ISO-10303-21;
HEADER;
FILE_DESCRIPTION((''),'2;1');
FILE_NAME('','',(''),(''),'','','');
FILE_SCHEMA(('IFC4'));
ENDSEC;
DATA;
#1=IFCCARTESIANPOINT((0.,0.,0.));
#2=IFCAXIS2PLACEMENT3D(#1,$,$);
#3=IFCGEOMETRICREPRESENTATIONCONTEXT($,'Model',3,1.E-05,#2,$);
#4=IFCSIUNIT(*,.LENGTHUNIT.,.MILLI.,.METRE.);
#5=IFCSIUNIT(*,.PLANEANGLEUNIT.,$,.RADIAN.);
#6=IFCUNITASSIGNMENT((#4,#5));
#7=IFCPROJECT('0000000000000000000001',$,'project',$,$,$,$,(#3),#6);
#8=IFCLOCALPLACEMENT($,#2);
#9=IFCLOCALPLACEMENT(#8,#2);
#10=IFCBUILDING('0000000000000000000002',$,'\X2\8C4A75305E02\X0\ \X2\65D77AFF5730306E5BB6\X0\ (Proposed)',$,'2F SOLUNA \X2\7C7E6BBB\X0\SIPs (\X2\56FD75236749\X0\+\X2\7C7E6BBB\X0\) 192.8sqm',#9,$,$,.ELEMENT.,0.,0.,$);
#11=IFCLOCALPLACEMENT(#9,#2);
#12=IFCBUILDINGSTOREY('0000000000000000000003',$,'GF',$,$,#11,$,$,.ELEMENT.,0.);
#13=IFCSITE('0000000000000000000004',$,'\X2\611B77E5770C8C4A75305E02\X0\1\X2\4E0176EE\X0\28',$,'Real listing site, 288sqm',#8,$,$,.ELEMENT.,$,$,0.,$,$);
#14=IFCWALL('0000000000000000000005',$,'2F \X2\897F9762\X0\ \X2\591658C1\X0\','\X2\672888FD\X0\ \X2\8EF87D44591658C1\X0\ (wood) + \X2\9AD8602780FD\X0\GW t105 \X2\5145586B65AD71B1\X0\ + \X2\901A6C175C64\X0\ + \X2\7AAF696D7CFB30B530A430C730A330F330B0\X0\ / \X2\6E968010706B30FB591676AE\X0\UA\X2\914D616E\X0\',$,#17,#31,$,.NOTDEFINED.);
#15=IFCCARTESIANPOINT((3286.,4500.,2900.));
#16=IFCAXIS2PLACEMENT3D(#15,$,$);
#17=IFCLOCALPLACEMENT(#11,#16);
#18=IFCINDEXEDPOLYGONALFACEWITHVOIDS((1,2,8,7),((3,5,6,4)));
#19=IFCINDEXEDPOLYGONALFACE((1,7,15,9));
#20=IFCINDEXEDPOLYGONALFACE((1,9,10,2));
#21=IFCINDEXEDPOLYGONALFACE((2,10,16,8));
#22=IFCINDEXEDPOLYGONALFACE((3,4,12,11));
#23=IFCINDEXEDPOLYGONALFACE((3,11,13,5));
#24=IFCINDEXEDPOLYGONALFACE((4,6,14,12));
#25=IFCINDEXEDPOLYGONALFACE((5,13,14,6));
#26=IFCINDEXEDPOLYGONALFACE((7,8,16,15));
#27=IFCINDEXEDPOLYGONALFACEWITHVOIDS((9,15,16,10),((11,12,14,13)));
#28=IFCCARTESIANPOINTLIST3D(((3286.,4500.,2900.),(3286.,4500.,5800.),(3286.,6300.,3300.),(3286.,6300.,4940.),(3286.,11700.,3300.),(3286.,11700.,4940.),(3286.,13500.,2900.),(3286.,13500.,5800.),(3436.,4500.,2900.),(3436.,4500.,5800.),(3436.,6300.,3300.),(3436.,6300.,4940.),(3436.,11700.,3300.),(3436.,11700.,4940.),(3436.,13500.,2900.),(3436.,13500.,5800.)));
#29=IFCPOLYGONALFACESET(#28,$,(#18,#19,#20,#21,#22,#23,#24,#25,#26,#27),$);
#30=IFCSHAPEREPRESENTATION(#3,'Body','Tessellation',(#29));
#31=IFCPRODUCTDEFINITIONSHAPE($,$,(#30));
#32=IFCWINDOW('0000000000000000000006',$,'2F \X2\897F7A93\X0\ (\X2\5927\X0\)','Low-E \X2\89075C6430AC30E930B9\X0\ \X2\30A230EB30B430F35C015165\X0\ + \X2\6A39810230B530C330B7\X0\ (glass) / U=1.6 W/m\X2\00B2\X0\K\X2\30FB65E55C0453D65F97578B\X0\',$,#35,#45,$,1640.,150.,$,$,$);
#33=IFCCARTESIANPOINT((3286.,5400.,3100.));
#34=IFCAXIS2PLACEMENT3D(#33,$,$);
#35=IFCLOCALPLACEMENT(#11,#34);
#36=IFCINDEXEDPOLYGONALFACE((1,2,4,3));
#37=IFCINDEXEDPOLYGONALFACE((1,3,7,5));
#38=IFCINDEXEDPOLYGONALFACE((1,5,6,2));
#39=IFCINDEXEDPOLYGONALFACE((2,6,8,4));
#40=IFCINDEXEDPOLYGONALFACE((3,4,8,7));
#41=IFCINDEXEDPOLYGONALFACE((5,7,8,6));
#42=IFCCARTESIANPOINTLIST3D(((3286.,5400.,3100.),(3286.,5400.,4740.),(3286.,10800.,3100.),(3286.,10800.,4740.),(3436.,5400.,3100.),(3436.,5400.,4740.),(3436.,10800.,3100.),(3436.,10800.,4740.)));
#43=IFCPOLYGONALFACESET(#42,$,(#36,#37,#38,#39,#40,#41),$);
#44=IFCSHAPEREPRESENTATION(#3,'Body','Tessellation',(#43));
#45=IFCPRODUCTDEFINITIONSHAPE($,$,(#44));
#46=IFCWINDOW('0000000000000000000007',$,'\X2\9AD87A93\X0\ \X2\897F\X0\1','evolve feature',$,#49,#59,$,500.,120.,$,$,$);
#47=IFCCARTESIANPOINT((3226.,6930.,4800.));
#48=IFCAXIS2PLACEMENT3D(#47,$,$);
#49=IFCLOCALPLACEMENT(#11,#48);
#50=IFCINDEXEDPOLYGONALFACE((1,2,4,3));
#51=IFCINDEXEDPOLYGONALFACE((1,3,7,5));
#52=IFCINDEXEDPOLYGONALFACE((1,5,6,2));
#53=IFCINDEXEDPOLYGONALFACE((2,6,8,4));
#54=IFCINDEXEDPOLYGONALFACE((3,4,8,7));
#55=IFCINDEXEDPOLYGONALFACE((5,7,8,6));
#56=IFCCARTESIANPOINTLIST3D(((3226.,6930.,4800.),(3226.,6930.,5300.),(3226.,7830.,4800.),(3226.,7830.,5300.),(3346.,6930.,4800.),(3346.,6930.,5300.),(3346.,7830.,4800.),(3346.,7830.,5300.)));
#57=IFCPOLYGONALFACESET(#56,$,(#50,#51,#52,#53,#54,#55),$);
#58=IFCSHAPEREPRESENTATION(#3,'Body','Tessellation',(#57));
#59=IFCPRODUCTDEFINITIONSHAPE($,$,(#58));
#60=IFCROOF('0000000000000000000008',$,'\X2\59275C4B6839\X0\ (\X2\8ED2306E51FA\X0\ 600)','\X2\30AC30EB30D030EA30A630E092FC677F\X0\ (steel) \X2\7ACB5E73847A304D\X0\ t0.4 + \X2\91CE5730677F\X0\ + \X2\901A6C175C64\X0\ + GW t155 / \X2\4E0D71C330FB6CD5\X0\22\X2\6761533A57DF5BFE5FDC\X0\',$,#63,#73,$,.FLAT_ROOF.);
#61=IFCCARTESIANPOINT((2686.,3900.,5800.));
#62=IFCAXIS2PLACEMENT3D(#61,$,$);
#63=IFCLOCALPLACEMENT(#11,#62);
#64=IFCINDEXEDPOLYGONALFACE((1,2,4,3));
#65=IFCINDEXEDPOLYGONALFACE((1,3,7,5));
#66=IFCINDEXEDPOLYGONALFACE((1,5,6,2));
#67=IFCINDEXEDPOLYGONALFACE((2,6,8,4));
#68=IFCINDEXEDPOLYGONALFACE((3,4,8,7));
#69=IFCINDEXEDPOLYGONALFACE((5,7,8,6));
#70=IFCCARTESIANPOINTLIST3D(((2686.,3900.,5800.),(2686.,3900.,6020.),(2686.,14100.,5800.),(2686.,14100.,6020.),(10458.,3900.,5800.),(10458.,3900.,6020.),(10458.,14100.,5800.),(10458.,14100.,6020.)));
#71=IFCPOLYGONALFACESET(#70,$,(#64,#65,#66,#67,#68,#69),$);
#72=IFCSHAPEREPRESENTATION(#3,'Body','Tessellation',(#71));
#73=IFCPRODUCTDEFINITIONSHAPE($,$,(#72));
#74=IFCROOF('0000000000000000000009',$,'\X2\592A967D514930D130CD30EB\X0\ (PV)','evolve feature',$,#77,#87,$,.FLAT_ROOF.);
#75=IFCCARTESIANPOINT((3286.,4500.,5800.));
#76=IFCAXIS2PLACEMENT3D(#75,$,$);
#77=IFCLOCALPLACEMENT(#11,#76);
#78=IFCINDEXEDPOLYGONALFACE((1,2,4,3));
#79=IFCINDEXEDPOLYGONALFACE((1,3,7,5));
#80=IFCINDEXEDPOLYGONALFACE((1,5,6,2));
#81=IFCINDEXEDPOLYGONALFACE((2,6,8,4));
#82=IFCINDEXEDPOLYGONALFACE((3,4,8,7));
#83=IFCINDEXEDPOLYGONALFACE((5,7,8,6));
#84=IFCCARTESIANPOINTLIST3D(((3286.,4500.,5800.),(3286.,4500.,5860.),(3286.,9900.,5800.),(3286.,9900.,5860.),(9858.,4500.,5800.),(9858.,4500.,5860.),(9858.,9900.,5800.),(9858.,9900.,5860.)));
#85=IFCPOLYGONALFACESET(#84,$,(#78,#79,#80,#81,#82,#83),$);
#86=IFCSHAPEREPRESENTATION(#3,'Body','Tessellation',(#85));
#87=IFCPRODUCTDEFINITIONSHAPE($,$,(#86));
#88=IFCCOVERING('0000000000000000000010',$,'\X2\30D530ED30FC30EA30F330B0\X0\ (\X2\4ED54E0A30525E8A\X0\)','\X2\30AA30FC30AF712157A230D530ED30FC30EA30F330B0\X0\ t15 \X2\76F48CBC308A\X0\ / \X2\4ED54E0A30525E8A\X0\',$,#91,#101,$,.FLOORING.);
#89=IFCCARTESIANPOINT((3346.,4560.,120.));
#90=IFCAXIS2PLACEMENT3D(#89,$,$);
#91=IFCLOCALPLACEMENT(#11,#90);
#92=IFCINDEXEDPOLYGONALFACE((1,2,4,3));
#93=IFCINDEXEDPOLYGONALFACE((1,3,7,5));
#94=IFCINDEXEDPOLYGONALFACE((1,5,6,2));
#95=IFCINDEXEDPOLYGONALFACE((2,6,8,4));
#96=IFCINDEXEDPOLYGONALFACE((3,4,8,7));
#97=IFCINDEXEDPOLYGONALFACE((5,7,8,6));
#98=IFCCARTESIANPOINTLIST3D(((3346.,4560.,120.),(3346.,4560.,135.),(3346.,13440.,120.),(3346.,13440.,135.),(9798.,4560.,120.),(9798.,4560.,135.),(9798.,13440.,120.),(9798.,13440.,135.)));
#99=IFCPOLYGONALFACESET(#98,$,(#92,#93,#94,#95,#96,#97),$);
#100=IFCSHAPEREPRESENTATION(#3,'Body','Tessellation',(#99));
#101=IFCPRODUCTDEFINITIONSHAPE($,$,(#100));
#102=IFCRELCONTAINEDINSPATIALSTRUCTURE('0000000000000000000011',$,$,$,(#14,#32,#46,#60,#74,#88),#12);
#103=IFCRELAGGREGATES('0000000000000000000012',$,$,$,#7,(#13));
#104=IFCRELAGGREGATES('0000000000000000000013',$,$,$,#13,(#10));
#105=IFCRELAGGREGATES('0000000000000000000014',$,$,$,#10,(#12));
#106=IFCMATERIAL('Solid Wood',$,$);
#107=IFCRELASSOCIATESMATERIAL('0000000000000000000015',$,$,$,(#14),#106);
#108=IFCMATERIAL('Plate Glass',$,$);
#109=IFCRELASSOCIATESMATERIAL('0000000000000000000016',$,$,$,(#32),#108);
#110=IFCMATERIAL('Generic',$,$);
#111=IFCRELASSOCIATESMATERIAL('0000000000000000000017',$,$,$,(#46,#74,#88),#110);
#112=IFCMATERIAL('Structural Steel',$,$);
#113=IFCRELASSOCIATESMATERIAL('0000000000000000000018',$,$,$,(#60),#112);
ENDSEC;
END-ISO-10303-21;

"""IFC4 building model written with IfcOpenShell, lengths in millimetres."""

from ifc_helpers import new_model, si_unit, frame, frame_2d, origin, place, context, project, spatial, rectangle, extrude, material, element, fill, save


model = new_model("IFC4")

# Units and contexts
model_context = context("Model", 3, precision=1e-05, world=origin())
ifc_project = project(units=[si_unit("LENGTHUNIT", "METRE", prefix="MILLI"), si_unit("PLANEANGLEUNIT", "RADIAN")], contexts=[model_context])

# Site, building, storey
site_placement = place(None, origin())
site = spatial("IfcSite", under=ifc_project, at=site_placement, Name="愛知県豊田市1丁目28", ObjectType="Real listing site, 288sqm", CompositionType="ELEMENT", RefElevation=0.0)
building_placement = place(site_placement, origin())
building = spatial("IfcBuilding", under=site, at=building_placement, Name="豊田市 旗竿地の家 (Proposed)", ObjectType="2F SOLUNA 籾殻SIPs (国産杉+籾殻) 192.8sqm", CompositionType="ELEMENT", ElevationOfRefHeight=0.0, ElevationOfTerrain=0.0)
storey_placement = place(building_placement, origin())
storey = spatial("IfcBuildingStorey", under=building, at=storey_placement, Name="GF", CompositionType="ELEMENT", Elevation=0.0)

# Shared definitions
ifc_material_1 = material(Name="Solid Wood")

# Shared definitions
ifc_material_2 = material(Name="Plate Glass")
ifc_material_3 = material(Name="Generic")

# Wall, openings, windows
wall_1_placement = place(storey_placement, frame((3286.0, 4500.0, 2900.0)))
wall_1 = element("IfcWall", 1, at=wall_1_placement, inside=storey, material=ifc_material_1, Name="2F 西面 外壁", Description="木製 軸組外壁 (wood) + 高性能GW t105 充填断熱 + 通気層 + 窯業系サイディング / 準耐火・外皮UA配慮", PredefinedType="NOTDEFINED", context=model_context, shape_type="SweptSolid", body=[
    extrude(rectangle(XDim=150.0, YDim=9000.0, at=frame_2d((75.0, 4500.0))), frame((3286.0, 4500.0, 2900.0)), (0.0, 0.0, 1.0), 2900.0),
])
opening_1_placement = place(storey_placement, frame((3286.0, 5400.0, 3100.0)))
opening_1 = element("IfcOpeningElement", 2, at=opening_1_placement, cuts=wall_1, PredefinedType="NOTDEFINED", context=model_context, shape_type="SweptSolid", body=[
    extrude(rectangle(XDim=150.0, YDim=5400.0, at=frame_2d((75.0, 2700.0))), frame((3286.0, 5400.0, 3100.0)), (0.0, 0.0, 1.0), 1640.0),
])
opening_2_placement = place(storey_placement, frame((3226.0, 6930.0, 4800.0)))
opening_2 = element("IfcOpeningElement", 3, at=opening_2_placement, cuts=wall_1, PredefinedType="NOTDEFINED", context=model_context, shape_type="SweptSolid", body=[
    extrude(rectangle(XDim=120.0, YDim=900.0, at=frame_2d((60.0, 450.0))), frame((3226.0, 6930.0, 4800.0)), (0.0, 0.0, 1.0), 500.0),
])
window_1_placement = place(storey_placement, frame((3286.0, 5400.0, 3100.0)))
window_1 = element("IfcWindow", 4, at=window_1_placement, inside=storey, material=ifc_material_2, Name="2F 西窓 (大)", Description="Low-E 複層ガラス アルゴン封入 + 樹脂サッシ (glass) / U=1.6 W/m²K・日射取得型", OverallHeight=1640.0, OverallWidth=150.0, context=model_context, shape_type="SweptSolid", body=[
    extrude(rectangle(XDim=150.0, YDim=5400.0, at=frame_2d((75.0, 2700.0))), frame((3286.0, 5400.0, 3100.0)), (0.0, 0.0, 1.0), 1640.0),
])
fill(opening_1, window_1)
window_2_placement = place(storey_placement, frame((3226.0, 6930.0, 4800.0)))
window_2 = element("IfcWindow", 5, at=window_2_placement, inside=storey, material=ifc_material_3, Name="高窓 西1", Description="evolve feature", OverallHeight=500.0, OverallWidth=120.0, context=model_context, shape_type="SweptSolid", body=[
    extrude(rectangle(XDim=120.0, YDim=900.0, at=frame_2d((60.0, 450.0))), frame((3226.0, 6930.0, 4800.0)), (0.0, 0.0, 1.0), 500.0),
])
fill(opening_2, window_2)

# Roofs
ifc_material_4 = material(Name="Structural Steel")
roof_1_placement = place(storey_placement, frame((2686.0, 3900.0, 5800.0)))
element("IfcRoof", 6, at=roof_1_placement, inside=storey, material=ifc_material_4, Name="大屋根 (軒の出 600)", Description="ガルバリウム鋼板 (steel) 立平葺き t0.4 + 野地板 + 通気層 + GW t155 / 不燃・法22条区域対応", PredefinedType="FLAT_ROOF", context=model_context, shape_type="SweptSolid", body=[
    extrude(rectangle(XDim=7772.0, YDim=10200.0, at=frame_2d((3886.0, 5100.0))), frame((2686.0, 3900.0, 5800.0)), (0.0, 0.0, 1.0), 220.0),
])
roof_2_placement = place(storey_placement, frame((3286.0, 4500.0, 5800.0)))
element("IfcRoof", 7, at=roof_2_placement, inside=storey, material=ifc_material_3, Name="太陽光パネル (PV)", Description="evolve feature", PredefinedType="FLAT_ROOF", context=model_context, shape_type="SweptSolid", body=[
    extrude(rectangle(XDim=6572.0, YDim=5400.0, at=frame_2d((3286.0, 2700.0))), frame((3286.0, 4500.0, 5800.0)), (0.0, 0.0, 1.0), 60.0),
])

# Covering
covering_placement = place(storey_placement, frame((3346.0, 4560.0, 120.0)))
element("IfcCovering", 8, at=covering_placement, inside=storey, material=ifc_material_3, Name="フローリング (仕上げ床)", Description="オーク無垢フローリング t15 直貼り / 仕上げ床", PredefinedType="FLOORING", context=model_context, shape_type="SweptSolid", body=[
    extrude(rectangle(XDim=6452.0, YDim=8880.0, at=frame_2d((3226.0, 4440.0))), frame((3346.0, 4560.0, 120.0)), (0.0, 0.0, 1.0), 15.0),
])

save(model, "model.ifc")
